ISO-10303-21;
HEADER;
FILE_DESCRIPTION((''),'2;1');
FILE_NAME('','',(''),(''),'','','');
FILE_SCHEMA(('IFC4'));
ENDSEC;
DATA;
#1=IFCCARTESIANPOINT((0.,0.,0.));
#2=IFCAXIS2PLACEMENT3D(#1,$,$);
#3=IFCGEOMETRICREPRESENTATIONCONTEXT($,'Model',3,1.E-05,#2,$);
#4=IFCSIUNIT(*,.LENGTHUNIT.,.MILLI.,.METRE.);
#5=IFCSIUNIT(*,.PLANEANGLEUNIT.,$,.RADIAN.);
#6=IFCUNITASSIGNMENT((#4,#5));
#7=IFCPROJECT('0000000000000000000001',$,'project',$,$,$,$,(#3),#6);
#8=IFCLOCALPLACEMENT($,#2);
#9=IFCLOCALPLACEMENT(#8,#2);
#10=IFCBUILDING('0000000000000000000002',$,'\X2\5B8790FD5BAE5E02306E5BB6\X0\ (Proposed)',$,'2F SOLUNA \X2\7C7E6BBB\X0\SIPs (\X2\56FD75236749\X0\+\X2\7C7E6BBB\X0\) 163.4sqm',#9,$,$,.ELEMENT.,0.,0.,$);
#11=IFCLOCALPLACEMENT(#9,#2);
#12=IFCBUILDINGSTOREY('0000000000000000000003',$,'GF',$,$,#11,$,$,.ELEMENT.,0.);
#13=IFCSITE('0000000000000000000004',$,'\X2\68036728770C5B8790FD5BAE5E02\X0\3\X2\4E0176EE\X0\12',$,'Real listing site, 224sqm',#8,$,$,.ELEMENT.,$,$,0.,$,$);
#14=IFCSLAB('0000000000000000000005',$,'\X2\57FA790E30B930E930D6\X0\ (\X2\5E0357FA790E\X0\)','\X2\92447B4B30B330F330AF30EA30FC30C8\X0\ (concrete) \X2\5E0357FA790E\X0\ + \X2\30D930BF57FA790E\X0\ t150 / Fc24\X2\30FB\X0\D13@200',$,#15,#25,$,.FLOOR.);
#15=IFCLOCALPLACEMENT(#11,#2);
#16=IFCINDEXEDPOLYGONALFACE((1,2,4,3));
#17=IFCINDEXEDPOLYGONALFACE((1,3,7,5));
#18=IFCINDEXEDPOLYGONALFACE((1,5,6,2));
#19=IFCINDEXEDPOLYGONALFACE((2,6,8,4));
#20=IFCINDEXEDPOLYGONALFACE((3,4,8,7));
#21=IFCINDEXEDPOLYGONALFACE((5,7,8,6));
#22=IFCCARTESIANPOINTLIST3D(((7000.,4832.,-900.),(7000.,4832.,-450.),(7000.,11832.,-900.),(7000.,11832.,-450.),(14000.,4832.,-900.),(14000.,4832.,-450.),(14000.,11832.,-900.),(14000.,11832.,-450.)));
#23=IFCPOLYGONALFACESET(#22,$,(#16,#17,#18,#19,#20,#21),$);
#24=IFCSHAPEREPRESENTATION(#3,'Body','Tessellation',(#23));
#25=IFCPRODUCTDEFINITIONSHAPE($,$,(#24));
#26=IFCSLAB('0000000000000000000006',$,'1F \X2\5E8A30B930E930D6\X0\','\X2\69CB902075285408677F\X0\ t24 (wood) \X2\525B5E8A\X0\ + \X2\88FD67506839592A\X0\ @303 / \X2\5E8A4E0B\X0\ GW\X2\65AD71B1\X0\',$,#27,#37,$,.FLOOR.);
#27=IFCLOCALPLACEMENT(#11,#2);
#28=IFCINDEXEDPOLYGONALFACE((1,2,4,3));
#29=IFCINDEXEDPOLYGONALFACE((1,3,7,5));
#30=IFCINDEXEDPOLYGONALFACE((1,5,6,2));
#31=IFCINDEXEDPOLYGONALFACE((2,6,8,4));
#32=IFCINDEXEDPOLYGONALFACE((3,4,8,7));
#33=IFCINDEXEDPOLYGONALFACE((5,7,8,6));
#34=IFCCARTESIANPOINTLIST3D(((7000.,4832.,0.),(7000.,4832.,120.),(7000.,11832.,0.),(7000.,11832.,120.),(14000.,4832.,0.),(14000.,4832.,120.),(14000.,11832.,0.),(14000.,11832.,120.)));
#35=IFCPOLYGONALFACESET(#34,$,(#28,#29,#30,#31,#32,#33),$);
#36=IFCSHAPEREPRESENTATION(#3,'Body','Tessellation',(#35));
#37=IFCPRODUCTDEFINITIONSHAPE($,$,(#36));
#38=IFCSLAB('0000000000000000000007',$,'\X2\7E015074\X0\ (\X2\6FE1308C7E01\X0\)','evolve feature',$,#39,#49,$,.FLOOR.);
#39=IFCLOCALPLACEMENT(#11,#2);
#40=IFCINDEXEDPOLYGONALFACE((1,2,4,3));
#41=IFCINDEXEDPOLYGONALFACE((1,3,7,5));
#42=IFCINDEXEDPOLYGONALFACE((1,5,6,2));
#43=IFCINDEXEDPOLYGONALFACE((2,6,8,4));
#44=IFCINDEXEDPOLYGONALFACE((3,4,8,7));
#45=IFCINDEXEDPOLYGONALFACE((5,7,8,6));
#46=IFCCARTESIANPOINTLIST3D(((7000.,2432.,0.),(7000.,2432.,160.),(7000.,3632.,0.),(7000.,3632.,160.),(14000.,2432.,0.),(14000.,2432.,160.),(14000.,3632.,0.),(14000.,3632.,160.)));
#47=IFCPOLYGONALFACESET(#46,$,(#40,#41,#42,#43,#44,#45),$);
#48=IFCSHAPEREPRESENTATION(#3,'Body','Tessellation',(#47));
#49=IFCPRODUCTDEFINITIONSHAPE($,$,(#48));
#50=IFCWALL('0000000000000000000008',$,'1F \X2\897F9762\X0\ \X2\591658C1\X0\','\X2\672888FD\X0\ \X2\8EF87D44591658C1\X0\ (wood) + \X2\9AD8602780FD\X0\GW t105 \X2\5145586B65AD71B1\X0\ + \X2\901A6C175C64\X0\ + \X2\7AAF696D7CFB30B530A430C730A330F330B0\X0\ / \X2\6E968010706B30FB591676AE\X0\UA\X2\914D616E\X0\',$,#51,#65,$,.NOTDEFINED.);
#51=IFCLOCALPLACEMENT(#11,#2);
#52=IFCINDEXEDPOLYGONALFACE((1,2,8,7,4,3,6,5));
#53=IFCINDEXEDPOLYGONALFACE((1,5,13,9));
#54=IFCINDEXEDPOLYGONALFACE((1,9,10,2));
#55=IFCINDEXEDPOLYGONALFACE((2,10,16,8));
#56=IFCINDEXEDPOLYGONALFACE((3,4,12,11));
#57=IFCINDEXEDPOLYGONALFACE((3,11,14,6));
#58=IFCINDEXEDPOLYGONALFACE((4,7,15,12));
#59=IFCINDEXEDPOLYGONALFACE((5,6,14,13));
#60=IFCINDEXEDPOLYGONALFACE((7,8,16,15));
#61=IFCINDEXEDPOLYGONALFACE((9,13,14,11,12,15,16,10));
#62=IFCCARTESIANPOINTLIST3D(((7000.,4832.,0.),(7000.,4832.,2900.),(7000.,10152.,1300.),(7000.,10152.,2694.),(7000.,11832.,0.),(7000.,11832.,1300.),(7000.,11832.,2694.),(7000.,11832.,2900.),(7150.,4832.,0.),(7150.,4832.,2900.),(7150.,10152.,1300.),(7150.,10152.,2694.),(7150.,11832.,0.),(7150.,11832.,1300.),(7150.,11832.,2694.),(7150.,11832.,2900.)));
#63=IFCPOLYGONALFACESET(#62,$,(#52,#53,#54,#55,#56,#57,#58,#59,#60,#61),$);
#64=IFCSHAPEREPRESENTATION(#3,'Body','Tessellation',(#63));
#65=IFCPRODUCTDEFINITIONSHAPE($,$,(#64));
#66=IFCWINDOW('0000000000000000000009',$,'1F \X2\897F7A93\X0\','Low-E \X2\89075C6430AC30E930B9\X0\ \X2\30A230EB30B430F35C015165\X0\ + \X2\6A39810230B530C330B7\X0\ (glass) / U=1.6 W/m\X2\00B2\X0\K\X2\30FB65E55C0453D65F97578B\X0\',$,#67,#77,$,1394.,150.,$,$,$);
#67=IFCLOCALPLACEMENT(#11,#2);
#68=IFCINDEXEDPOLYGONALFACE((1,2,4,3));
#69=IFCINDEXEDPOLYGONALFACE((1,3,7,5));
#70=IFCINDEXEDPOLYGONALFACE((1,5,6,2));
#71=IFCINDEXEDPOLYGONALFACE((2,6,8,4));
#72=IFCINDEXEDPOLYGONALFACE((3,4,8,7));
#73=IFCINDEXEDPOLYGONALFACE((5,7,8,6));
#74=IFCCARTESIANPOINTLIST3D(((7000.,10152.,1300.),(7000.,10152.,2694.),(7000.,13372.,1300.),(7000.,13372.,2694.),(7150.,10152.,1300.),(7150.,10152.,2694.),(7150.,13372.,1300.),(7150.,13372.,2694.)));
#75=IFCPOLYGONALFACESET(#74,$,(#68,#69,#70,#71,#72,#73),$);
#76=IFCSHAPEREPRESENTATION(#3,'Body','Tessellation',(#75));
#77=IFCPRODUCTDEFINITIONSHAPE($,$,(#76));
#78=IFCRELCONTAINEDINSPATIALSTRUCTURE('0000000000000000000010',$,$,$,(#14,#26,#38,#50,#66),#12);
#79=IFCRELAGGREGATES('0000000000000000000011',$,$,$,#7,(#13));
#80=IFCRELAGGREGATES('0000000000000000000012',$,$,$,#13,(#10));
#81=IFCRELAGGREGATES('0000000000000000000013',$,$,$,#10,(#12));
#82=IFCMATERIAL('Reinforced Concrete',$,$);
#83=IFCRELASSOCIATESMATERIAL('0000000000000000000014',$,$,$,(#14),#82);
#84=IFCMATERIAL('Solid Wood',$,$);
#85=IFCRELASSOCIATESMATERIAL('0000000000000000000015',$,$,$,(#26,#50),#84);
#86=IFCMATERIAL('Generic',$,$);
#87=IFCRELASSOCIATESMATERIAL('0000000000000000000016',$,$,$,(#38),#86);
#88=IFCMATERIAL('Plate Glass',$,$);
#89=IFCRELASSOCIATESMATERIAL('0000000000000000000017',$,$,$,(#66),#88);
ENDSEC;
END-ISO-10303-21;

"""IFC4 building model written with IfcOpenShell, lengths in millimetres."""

from ifc_helpers import new_model, si_unit, frame, frame_2d, origin, place, context, project, spatial, rectangle, extrude, material, element, fill, save


model = new_model("IFC4")

# Units and contexts
model_context = context("Model", 3, precision=1e-05, world=origin())
ifc_project = project(units=[si_unit("LENGTHUNIT", "METRE", prefix="MILLI"), si_unit("PLANEANGLEUNIT", "RADIAN")], contexts=[model_context])

# Site, building, storey
site_placement = place(None, origin())
site = spatial("IfcSite", under=ifc_project, at=site_placement, Name="栃木県宇都宮市3丁目12", ObjectType="Real listing site, 224sqm", CompositionType="ELEMENT", RefElevation=0.0)
building_placement = place(site_placement, origin())
building = spatial("IfcBuilding", under=site, at=building_placement, Name="宇都宮市の家 (Proposed)", ObjectType="2F SOLUNA 籾殻SIPs (国産杉+籾殻) 163.4sqm", CompositionType="ELEMENT", ElevationOfRefHeight=0.0, ElevationOfTerrain=0.0)
storey_placement = place(building_placement, origin())
storey = spatial("IfcBuildingStorey", under=building, at=storey_placement, Name="GF", CompositionType="ELEMENT", Elevation=0.0)

# Slabs
ifc_material_1 = material(Name="Reinforced Concrete")
slab_1_placement = place(storey_placement, frame((3500.0, 2416.0, -450.0)))
element("IfcSlab", 1, at=slab_1_placement, inside=storey, material=ifc_material_1, Name="基礎スラブ (布基礎)", Description="鉄筋コンクリート (concrete) 布基礎 + ベタ基礎 t150 / Fc24・D13@200", PredefinedType="FLOOR", context=model_context, shape_type="SweptSolid", body=[
    extrude(rectangle(XDim=7000.0, YDim=7000.0, at=frame_2d((3500.0, 3500.0))), frame((3500.0, 2416.0, -450.0)), (0.0, 0.0, 1.0), 450.0),
])
ifc_material_2 = material(Name="Solid Wood")
slab_2_placement = place(storey_placement, frame((3500.0, 2416.0, 0.0)))
element("IfcSlab", 2, at=slab_2_placement, inside=storey, material=ifc_material_2, Name="1F 床スラブ", Description="構造用合板 t24 (wood) 剛床 + 製材根太 @303 / 床下 GW断熱", PredefinedType="FLOOR", context=model_context, shape_type="SweptSolid", body=[
    extrude(rectangle(XDim=7000.0, YDim=7000.0, at=frame_2d((3500.0, 3500.0))), frame((3500.0, 2416.0, 0.0)), (0.0, 0.0, 1.0), 120.0),
])
ifc_material_3 = material(Name="Generic")
slab_3_placement = place(storey_placement, frame((3500.0, 1216.0, 0.0)))
element("IfcSlab", 3, at=slab_3_placement, inside=storey, material=ifc_material_3, Name="縁側 (濡れ縁)", Description="evolve feature", PredefinedType="FLOOR", context=model_context, shape_type="SweptSolid", body=[
    extrude(rectangle(XDim=7000.0, YDim=1200.0, at=frame_2d((3500.0, 600.0))), frame((3500.0, 1216.0, 0.0)), (0.0, 0.0, 1.0), 160.0),
])

# Shared definitions
ifc_material_4 = material(Name="Plate Glass")

# Wall, opening, window
wall_1_placement = place(storey_placement, frame((3500.0, 2416.0, 0.0)))
wall_1 = element("IfcWall", 4, at=wall_1_placement, inside=storey, material=ifc_material_2, Name="1F 西面 外壁", Description="木製 軸組外壁 (wood) + 高性能GW t105 充填断熱 + 通気層 + 窯業系サイディング / 準耐火・外皮UA配慮", PredefinedType="NOTDEFINED", context=model_context, shape_type="SweptSolid", body=[
    extrude(rectangle(XDim=150.0, YDim=7000.0, at=frame_2d((75.0, 3500.0))), frame((3500.0, 2416.0, 0.0)), (0.0, 0.0, 1.0), 2900.0),
])
opening_1_placement = place(storey_placement, frame((3500.0, 5076.0, 650.0)))
opening_1 = element("IfcOpeningElement", 5, at=opening_1_placement, cuts=wall_1, PredefinedType="NOTDEFINED", context=model_context, shape_type="SweptSolid", body=[
    extrude(rectangle(XDim=150.0, YDim=3220.0, at=frame_2d((75.0, 1610.0))), frame((3500.0, 5076.0, 650.0)), (0.0, 0.0, 1.0), 1394.0),
])
window_1_placement = place(storey_placement, frame((3500.0, 5076.0, 650.0)))
window_1 = element("IfcWindow", 6, at=window_1_placement, inside=storey, material=ifc_material_4, Name="1F 西窓", Description="Low-E 複層ガラス アルゴン封入 + 樹脂サッシ (glass) / U=1.6 W/m²K・日射取得型", OverallHeight=1394.0, OverallWidth=150.0, context=model_context, shape_type="SweptSolid", body=[
    extrude(rectangle(XDim=150.0, YDim=3220.0, at=frame_2d((75.0, 1610.0))), frame((3500.0, 5076.0, 650.0)), (0.0, 0.0, 1.0), 1394.0),
])
fill(opening_1, window_1)

save(model, "model.ifc")
